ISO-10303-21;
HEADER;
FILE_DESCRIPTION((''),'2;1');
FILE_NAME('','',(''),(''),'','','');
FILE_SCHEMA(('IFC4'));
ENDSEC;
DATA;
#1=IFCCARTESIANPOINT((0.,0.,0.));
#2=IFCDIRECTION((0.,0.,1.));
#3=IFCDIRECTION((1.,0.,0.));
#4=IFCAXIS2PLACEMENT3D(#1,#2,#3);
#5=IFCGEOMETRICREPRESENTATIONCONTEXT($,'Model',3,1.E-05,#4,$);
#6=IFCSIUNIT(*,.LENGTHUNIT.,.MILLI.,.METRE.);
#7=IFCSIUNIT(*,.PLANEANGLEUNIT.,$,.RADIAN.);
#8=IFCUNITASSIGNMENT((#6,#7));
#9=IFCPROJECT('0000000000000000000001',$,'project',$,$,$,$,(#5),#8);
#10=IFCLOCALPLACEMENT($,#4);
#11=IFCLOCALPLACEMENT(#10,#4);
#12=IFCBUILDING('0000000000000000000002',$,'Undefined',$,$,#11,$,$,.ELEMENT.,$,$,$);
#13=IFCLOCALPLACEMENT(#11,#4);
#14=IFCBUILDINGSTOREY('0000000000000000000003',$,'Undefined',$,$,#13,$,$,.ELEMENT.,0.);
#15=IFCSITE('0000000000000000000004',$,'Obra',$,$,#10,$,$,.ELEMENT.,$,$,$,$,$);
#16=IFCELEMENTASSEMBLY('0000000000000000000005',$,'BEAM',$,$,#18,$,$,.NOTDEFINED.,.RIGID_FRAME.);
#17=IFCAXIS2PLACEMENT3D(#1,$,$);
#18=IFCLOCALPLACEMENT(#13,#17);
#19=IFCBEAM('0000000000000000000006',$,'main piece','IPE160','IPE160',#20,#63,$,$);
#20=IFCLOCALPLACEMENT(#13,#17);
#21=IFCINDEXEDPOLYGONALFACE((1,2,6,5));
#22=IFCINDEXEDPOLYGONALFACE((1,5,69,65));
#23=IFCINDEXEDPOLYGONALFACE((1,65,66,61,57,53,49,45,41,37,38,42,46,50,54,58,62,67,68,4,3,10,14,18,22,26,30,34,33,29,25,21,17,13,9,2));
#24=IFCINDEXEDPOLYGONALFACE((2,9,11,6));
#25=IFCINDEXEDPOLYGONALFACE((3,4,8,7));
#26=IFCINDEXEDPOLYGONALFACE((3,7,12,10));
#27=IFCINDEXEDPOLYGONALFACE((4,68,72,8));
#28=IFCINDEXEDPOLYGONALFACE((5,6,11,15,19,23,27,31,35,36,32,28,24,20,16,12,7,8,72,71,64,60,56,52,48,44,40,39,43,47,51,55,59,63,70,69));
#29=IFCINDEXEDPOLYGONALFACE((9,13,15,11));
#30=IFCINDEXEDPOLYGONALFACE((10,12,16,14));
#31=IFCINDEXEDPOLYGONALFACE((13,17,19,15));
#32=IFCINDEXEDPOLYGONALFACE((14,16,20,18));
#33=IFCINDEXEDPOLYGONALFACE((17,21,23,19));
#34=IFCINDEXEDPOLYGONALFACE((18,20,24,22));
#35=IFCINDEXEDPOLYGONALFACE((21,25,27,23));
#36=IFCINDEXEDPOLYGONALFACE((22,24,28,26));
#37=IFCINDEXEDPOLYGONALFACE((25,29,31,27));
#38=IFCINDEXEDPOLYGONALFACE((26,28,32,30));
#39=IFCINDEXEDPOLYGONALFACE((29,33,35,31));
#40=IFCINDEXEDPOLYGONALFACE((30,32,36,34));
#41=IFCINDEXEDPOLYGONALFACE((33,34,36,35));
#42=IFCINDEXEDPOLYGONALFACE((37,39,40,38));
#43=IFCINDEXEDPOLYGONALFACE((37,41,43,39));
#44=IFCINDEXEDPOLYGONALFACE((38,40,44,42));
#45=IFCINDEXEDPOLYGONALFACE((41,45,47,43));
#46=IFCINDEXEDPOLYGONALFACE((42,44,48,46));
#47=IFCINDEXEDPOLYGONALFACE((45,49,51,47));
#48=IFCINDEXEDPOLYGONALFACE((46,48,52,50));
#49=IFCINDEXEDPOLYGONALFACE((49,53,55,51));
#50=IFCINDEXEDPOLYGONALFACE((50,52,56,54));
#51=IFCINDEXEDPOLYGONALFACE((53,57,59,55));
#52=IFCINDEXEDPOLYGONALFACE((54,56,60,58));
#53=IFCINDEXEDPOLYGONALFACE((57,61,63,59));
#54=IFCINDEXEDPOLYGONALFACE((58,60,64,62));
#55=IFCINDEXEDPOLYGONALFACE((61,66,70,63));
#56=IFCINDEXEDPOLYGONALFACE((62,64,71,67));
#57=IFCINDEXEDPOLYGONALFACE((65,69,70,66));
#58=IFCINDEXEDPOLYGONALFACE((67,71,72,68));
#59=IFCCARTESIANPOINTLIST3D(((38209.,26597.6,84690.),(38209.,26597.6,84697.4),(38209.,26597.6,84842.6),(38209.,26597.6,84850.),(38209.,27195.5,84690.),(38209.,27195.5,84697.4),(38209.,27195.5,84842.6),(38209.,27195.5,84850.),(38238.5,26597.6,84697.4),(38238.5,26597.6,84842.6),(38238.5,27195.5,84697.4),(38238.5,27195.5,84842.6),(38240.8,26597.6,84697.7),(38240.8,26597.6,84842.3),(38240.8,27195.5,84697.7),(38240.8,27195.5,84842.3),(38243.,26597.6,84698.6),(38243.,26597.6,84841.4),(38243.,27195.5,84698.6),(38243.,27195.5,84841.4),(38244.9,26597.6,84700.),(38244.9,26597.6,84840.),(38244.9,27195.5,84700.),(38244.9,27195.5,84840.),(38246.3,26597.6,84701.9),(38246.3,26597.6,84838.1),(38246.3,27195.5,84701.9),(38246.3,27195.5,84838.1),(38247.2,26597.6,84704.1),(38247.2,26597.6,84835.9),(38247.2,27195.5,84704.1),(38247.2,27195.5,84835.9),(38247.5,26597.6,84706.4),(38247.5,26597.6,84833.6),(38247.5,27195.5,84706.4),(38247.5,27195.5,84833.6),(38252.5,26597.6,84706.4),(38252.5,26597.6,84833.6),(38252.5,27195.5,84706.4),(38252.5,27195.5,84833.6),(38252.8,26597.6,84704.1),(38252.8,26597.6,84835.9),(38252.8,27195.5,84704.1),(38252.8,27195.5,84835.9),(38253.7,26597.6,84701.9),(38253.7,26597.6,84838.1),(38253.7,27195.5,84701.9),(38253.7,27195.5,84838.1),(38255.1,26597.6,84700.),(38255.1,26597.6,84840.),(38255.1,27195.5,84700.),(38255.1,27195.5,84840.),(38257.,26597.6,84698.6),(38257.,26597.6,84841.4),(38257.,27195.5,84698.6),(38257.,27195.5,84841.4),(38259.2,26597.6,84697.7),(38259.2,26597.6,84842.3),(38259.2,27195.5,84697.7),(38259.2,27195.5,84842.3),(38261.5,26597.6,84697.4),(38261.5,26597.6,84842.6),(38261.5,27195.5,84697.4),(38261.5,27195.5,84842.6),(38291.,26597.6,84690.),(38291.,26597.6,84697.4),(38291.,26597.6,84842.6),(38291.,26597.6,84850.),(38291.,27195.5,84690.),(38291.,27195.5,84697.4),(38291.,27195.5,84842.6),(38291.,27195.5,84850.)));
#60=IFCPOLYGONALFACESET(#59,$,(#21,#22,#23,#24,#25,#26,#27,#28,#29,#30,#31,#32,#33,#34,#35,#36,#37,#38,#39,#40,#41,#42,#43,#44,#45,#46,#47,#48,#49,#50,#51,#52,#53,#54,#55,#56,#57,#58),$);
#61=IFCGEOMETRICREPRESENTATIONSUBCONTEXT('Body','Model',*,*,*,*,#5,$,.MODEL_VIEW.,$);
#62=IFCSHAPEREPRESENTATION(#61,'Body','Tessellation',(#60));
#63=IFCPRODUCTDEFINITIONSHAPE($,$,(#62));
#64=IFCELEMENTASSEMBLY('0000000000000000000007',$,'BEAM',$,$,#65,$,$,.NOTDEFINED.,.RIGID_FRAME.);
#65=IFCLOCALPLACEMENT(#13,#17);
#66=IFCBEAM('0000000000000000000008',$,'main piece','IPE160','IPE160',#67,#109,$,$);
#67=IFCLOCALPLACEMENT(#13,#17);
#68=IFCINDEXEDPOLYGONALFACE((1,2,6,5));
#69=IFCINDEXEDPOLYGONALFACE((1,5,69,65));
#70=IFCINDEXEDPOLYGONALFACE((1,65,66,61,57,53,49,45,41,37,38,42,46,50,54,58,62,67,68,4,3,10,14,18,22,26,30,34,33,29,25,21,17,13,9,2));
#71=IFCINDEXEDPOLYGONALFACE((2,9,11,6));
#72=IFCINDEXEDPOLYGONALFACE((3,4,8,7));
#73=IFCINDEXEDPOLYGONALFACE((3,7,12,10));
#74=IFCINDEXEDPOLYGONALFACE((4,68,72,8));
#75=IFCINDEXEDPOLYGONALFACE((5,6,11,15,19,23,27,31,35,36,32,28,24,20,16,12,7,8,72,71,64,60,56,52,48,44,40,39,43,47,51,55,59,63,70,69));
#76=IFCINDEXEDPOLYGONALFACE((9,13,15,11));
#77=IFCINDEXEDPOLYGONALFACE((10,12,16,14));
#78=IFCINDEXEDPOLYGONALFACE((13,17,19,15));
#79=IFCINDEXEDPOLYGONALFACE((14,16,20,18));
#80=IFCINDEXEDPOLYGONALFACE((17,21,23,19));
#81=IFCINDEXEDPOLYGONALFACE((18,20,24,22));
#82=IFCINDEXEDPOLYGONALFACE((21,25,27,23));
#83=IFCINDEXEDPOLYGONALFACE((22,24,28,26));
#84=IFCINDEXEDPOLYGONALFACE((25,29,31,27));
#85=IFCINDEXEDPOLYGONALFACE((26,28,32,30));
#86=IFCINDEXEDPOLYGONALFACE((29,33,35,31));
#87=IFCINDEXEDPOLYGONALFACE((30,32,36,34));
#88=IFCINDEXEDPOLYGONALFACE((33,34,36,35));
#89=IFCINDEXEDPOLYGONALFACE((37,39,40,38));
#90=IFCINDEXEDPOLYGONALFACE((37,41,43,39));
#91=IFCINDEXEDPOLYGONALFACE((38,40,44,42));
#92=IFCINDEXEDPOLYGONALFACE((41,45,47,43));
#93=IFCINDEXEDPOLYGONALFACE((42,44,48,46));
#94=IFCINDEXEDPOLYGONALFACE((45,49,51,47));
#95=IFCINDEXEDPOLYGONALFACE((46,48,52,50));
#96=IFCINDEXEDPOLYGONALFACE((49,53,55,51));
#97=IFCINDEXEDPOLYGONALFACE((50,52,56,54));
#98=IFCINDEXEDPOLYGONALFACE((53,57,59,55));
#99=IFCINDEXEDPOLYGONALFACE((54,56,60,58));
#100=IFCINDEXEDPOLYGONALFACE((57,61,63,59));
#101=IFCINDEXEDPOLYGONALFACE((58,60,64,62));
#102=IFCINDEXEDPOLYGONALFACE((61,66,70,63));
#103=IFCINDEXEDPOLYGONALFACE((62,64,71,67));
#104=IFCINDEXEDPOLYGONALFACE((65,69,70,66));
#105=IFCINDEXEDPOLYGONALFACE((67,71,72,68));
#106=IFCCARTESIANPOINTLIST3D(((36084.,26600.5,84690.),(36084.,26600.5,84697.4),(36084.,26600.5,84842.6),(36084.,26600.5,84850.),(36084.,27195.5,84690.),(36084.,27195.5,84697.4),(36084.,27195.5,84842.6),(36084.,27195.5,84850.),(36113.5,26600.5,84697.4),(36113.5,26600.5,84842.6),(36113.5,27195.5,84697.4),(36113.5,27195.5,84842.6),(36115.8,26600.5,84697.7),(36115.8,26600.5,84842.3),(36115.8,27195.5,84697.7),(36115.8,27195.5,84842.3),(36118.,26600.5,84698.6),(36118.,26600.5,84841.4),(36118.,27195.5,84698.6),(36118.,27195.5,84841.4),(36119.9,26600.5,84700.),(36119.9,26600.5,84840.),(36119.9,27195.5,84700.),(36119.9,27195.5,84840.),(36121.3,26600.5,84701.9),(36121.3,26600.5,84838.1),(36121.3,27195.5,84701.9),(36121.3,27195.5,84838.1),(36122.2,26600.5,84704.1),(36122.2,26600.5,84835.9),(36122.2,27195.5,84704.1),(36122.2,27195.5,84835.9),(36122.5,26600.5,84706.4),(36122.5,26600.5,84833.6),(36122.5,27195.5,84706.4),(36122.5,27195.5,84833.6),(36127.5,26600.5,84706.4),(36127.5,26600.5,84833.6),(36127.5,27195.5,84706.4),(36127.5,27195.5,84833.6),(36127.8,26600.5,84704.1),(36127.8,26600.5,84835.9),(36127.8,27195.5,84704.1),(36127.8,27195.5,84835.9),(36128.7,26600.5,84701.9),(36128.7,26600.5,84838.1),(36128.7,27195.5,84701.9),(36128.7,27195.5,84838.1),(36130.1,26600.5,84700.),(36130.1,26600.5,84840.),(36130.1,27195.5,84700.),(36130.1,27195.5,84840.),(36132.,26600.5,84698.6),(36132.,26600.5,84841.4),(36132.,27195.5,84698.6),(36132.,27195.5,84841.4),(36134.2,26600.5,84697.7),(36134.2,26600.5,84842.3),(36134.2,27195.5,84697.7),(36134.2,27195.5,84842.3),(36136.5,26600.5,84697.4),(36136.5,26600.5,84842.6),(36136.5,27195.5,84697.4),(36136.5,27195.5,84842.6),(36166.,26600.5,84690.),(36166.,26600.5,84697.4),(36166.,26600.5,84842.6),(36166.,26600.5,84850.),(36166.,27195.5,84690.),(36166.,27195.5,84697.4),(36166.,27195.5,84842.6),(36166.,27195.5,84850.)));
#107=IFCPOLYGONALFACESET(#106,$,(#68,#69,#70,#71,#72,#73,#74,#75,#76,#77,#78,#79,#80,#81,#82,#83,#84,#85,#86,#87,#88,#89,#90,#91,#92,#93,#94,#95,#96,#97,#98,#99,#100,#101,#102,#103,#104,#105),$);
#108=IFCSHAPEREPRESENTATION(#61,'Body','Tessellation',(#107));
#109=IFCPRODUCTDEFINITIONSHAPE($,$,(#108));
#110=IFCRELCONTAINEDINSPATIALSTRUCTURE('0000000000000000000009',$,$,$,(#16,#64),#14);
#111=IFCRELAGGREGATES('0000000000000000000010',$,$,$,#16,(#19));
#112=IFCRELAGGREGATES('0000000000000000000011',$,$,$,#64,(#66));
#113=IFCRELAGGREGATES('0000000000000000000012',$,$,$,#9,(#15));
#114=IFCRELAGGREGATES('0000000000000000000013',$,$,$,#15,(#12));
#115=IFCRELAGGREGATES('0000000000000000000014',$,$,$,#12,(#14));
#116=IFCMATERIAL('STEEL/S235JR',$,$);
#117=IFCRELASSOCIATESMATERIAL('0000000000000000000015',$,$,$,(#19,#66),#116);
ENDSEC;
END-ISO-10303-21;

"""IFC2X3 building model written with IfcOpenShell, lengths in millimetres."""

from ifc_helpers import new_model, si_unit, frame, origin_with_axes, origin_2d_with_axis, place, context, subcontext, project, spatial, i_section, extrude, material, element, aggregate, save


model = new_model("IFC2X3")

# Units and contexts
model_context = context("Model", 3, precision=1e-05, world=origin_with_axes())
body_context = subcontext(model_context, "Body", "Model", "MODEL_VIEW")
ifc_project = project(units=[si_unit("LENGTHUNIT", "METRE", prefix="MILLI"), si_unit("PLANEANGLEUNIT", "RADIAN")], contexts=[model_context])

# Site, building, storey
site_placement = place(None, origin_with_axes())
site = spatial("IfcSite", under=ifc_project, at=site_placement, Name="Obra", CompositionType="ELEMENT")
building_placement = place(site_placement, origin_with_axes())
building = spatial("IfcBuilding", under=site, at=building_placement, Name="Undefined", CompositionType="ELEMENT")
storey_placement = place(building_placement, origin_with_axes())
storey = spatial("IfcBuildingStorey", under=building, at=storey_placement, Name="Undefined", CompositionType="ELEMENT", Elevation=0.0)

# Element assemblies, beams
assembly_1_placement = place(storey_placement, origin_with_axes())
assembly_1 = element("IfcElementAssembly", 1, at=assembly_1_placement, inside=storey, Name="BEAM", AssemblyPlace="NOTDEFINED", PredefinedType="RIGID_FRAME")
ifc_material_1 = material(Name="STEEL/S235JR")
beam_1_placement = place(assembly_1_placement, frame((38250.0, 26597.6, 84770.0), z_axis=(0.0, 0.0, 1.0), x_axis=(0.0, 1.0, 0.0)))
beam_1 = element("IfcBeam", 2, at=beam_1_placement, material=ifc_material_1, Name="main piece", Description="IPE160", ObjectType="IPE160", context=body_context, shape_type="SweptSolid", body=[
    extrude(i_section(OverallWidth=82.0, OverallDepth=160.0, WebThickness=5.0, FlangeThickness=7.4, FilletRadius=9.0, at=origin_2d_with_axis()), frame((597.9, 0.0, 0.0), z_axis=(-1.0, 0.0, 0.0), x_axis=(0.0, -1.0, 0.0)), (0.0, 0.0, 1.0), 597.9),
])
aggregate(assembly_1, [beam_1])
assembly_2_placement = place(storey_placement, origin_with_axes())
assembly_2 = element("IfcElementAssembly", 3, at=assembly_2_placement, inside=storey, Name="BEAM", AssemblyPlace="NOTDEFINED", PredefinedType="RIGID_FRAME")
beam_2_placement = place(assembly_2_placement, frame((36125.0, 26600.5, 84770.0), z_axis=(0.0, 0.0, 1.0), x_axis=(0.0, 1.0, 0.0)))
beam_2 = element("IfcBeam", 4, at=beam_2_placement, material=ifc_material_1, Name="main piece", Description="IPE160", ObjectType="IPE160", context=body_context, shape_type="SweptSolid", body=[
    extrude(i_section(OverallWidth=82.0, OverallDepth=160.0, WebThickness=5.0, FlangeThickness=7.4, FilletRadius=9.0, at=origin_2d_with_axis()), frame((595.0, 0.0, 0.0), z_axis=(-1.0, 0.0, 0.0), x_axis=(0.0, -1.0, 0.0)), (0.0, 0.0, 1.0), 595.0),
])
aggregate(assembly_2, [beam_2])

save(model, "model.ifc")
